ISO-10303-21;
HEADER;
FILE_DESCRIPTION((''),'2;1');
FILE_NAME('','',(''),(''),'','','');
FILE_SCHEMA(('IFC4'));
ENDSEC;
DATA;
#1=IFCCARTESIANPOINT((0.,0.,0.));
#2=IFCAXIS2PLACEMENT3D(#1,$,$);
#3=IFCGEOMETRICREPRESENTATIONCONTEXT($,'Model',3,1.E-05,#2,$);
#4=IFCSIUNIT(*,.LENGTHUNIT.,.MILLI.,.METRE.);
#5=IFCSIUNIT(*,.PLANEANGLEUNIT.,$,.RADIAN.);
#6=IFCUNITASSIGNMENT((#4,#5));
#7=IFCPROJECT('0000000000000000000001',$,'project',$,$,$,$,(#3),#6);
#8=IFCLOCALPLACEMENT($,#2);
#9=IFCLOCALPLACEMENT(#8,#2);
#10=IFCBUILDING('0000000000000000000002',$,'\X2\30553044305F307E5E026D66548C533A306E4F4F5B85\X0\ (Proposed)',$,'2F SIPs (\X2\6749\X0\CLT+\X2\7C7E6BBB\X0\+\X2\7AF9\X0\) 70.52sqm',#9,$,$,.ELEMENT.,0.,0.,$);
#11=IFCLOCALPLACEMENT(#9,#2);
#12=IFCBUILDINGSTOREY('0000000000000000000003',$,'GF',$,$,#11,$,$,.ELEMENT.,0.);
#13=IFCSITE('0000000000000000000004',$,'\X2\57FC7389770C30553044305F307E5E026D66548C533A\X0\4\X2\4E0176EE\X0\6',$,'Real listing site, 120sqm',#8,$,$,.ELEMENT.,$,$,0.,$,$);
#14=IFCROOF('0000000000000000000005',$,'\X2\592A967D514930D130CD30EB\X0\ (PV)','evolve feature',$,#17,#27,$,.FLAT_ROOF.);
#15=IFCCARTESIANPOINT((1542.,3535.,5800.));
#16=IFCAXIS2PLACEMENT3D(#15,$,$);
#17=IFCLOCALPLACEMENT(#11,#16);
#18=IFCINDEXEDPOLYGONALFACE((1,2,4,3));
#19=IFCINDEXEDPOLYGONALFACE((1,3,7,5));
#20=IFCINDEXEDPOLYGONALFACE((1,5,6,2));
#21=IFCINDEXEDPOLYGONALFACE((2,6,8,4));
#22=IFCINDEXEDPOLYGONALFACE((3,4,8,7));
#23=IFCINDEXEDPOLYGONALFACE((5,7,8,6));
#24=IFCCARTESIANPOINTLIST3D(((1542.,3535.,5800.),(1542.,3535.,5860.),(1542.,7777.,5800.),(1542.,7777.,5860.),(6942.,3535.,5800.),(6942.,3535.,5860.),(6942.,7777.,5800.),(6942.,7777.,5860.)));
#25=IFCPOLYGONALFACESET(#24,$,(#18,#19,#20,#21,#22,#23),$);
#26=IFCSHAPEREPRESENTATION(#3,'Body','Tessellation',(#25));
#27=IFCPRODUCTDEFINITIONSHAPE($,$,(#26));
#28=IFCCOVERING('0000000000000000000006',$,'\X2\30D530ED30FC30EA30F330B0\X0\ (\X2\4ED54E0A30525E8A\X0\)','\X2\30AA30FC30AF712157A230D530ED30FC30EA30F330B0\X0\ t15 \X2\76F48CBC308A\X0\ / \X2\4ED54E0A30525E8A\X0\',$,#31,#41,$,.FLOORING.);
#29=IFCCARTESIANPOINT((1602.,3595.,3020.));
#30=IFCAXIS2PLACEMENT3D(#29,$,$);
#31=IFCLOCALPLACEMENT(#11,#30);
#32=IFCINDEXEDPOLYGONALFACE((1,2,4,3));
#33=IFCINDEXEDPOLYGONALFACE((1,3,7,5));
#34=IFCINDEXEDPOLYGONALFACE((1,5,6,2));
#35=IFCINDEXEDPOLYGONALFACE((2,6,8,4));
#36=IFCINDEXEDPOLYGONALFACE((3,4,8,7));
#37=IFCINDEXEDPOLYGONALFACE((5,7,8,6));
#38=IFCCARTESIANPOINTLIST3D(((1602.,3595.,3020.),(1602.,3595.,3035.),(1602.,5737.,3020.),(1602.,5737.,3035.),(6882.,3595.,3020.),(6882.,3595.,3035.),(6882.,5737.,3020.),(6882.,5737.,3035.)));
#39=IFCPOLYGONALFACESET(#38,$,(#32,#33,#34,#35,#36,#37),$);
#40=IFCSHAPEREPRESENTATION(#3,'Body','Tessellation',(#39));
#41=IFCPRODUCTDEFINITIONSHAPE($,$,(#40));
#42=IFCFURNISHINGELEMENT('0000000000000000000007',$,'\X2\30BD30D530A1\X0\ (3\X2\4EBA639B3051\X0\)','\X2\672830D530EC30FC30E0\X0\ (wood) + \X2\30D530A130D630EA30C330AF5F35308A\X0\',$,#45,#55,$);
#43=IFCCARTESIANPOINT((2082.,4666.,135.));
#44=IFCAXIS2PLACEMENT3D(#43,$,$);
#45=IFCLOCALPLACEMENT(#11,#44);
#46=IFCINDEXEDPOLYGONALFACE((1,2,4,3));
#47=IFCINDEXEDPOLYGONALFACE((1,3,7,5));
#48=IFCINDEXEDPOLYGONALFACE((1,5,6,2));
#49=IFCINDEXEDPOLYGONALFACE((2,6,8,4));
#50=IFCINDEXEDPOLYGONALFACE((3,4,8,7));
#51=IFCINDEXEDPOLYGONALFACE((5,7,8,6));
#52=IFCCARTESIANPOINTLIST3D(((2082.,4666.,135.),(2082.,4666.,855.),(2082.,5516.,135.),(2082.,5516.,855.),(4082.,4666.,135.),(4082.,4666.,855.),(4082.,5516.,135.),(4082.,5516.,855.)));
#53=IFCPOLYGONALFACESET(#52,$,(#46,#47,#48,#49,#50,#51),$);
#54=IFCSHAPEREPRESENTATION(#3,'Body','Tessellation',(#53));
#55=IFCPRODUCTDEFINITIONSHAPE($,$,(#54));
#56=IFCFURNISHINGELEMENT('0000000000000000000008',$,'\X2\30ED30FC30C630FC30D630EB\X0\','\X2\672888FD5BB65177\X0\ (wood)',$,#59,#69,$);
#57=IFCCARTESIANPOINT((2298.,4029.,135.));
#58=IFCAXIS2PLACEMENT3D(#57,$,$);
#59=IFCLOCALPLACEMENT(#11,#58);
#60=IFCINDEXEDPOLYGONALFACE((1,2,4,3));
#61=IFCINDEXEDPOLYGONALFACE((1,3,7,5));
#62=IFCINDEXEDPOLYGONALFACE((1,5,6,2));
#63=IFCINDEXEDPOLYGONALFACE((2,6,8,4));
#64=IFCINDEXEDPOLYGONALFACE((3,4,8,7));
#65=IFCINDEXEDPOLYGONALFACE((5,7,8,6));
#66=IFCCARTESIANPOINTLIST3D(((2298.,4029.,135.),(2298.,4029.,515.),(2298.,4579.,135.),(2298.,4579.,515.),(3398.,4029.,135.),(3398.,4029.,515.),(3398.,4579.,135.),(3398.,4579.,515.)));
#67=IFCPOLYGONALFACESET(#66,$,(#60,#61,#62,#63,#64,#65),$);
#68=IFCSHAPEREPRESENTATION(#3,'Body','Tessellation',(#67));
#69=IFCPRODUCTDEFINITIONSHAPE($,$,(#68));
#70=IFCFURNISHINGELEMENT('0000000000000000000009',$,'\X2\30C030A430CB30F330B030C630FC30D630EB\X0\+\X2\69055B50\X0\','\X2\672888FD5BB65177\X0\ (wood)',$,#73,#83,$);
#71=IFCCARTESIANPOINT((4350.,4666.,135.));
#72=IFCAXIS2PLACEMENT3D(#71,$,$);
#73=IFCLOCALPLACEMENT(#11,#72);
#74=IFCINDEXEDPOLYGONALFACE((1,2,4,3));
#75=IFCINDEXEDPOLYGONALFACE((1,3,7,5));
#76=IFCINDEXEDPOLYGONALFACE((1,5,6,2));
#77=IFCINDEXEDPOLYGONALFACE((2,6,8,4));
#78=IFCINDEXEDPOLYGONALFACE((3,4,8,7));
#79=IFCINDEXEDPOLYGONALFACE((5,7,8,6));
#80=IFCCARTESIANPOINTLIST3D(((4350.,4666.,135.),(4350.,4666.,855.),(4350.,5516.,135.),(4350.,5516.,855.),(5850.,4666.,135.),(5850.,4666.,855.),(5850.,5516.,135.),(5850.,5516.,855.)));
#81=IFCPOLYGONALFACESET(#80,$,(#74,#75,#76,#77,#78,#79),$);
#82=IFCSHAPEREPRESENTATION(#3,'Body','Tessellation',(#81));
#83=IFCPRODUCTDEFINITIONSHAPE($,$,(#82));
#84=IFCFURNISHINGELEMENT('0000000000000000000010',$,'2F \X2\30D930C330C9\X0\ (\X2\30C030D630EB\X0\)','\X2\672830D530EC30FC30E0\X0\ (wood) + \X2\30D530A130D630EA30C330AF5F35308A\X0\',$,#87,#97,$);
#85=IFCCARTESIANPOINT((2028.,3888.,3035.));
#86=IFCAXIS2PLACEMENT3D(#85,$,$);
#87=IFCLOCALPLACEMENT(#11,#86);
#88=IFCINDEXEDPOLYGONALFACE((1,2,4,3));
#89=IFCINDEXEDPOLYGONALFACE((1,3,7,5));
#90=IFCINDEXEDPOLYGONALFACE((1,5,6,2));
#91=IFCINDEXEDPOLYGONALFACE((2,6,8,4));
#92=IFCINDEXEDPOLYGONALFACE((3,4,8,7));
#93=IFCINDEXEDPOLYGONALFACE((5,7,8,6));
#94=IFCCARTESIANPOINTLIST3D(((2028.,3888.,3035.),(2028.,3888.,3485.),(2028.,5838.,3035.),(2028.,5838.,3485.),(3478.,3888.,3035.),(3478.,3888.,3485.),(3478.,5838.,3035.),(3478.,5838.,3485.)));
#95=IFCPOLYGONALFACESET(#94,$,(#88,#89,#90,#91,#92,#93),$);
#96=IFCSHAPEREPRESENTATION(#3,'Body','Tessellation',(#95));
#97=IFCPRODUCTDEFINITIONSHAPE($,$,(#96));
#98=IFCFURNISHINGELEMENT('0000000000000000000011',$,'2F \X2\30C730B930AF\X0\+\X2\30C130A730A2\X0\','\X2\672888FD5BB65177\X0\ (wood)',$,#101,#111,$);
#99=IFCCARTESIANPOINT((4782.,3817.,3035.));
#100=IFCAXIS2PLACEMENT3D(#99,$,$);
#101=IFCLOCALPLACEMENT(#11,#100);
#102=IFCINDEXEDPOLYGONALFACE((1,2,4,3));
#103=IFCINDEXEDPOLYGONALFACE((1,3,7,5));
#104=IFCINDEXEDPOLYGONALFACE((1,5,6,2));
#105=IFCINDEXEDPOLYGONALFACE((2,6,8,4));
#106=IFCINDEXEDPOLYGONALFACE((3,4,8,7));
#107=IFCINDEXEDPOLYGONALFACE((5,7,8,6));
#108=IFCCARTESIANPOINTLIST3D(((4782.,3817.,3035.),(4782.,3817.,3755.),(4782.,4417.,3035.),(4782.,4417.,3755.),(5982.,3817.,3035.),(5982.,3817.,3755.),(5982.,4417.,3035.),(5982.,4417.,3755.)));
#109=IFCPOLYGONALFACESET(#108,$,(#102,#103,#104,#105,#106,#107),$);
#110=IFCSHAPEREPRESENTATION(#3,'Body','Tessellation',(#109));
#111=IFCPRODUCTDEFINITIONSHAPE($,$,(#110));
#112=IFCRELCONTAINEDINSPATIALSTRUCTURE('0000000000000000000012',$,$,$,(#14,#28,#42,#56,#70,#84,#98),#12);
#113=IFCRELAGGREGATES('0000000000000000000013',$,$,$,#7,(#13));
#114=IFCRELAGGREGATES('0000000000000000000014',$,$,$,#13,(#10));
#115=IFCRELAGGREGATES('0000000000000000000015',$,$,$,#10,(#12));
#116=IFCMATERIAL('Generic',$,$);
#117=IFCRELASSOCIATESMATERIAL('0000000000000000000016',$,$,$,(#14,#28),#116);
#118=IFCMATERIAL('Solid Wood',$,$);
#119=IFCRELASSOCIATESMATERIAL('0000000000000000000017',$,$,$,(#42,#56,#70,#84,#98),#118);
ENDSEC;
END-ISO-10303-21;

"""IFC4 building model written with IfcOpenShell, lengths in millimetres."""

from ifc_helpers import new_model, si_unit, frame, frame_2d, origin, place, context, project, spatial, rectangle, extrude, material, element, save


model = new_model("IFC4")

# Units and contexts
model_context = context("Model", 3, precision=1e-05, world=origin())
ifc_project = project(units=[si_unit("LENGTHUNIT", "METRE", prefix="MILLI"), si_unit("PLANEANGLEUNIT", "RADIAN")], contexts=[model_context])

# Site, building, storey
site_placement = place(None, origin())
site = spatial("IfcSite", under=ifc_project, at=site_placement, Name="埼玉県さいたま市浦和区4丁目6", ObjectType="Real listing site, 120sqm", CompositionType="ELEMENT", RefElevation=0.0)
building_placement = place(site_placement, origin())
building = spatial("IfcBuilding", under=site, at=building_placement, Name="さいたま市浦和区の住宅 (Proposed)", ObjectType="2F SIPs (杉CLT+籾殻+竹) 70.52sqm", CompositionType="ELEMENT", ElevationOfRefHeight=0.0, ElevationOfTerrain=0.0)
storey_placement = place(building_placement, origin())
storey = spatial("IfcBuildingStorey", under=building, at=storey_placement, Name="GF", CompositionType="ELEMENT", Elevation=0.0)

# Shared definitions
ifc_material_1 = material(Name="Solid Wood")

# Shared definitions
ifc_material_2 = material(Name="Generic")

# Roof
roof_1_placement = place(storey_placement, frame((1542.0, 3535.0, 5800.0)))
element("IfcRoof", 1, at=roof_1_placement, inside=storey, material=ifc_material_2, Name="太陽光パネル (PV)", Description="evolve feature", PredefinedType="FLAT_ROOF", context=model_context, shape_type="SweptSolid", body=[
    extrude(rectangle(XDim=5400.0, YDim=4242.0, at=frame_2d((2700.0, 2121.0))), frame((1542.0, 3535.0, 5800.0)), (0.0, 0.0, 1.0), 60.0),
])

# Covering
covering_placement = place(storey_placement, frame((1602.0, 3595.0, 3020.0)))
element("IfcCovering", 2, at=covering_placement, inside=storey, material=ifc_material_2, Name="フローリング (仕上げ床)", Description="オーク無垢フローリング t15 直貼り / 仕上げ床", PredefinedType="FLOORING", context=model_context, shape_type="SweptSolid", body=[
    extrude(rectangle(XDim=5280.0, YDim=2142.0, at=frame_2d((2640.0, 1071.0))), frame((1602.0, 3595.0, 3020.0)), (0.0, 0.0, 1.0), 15.0),
])

# Furnishing elements
furnishing_1_placement = place(storey_placement, frame((2082.0, 4666.0, 135.0)))
element("IfcFurnishingElement", 3, at=furnishing_1_placement, inside=storey, material=ifc_material_1, Name="ソファ (3人掛け)", Description="木フレーム (wood) + ファブリック張り", context=model_context, shape_type="SweptSolid", body=[
    extrude(rectangle(XDim=2000.0, YDim=850.0, at=frame_2d((1000.0, 425.0))), frame((2082.0, 4666.0, 135.0)), (0.0, 0.0, 1.0), 720.0),
])
furnishing_2_placement = place(storey_placement, frame((2298.0, 4029.0, 135.0)))
element("IfcFurnishingElement", 4, at=furnishing_2_placement, inside=storey, material=ifc_material_1, Name="ローテーブル", Description="木製家具 (wood)", context=model_context, shape_type="SweptSolid", body=[
    extrude(rectangle(XDim=1100.0, YDim=550.0, at=frame_2d((550.0, 275.0))), frame((2298.0, 4029.0, 135.0)), (0.0, 0.0, 1.0), 380.0),
])
furnishing_3_placement = place(storey_placement, frame((4350.0, 4666.0, 135.0)))
element("IfcFurnishingElement", 5, at=furnishing_3_placement, inside=storey, material=ifc_material_1, Name="ダイニングテーブル+椅子", Description="木製家具 (wood)", context=model_context, shape_type="SweptSolid", body=[
    extrude(rectangle(XDim=1500.0, YDim=850.0, at=frame_2d((750.0, 425.0))), frame((4350.0, 4666.0, 135.0)), (0.0, 0.0, 1.0), 720.0),
])
furnishing_4_placement = place(storey_placement, frame((2028.0, 3888.0, 3035.0)))
element("IfcFurnishingElement", 6, at=furnishing_4_placement, inside=storey, material=ifc_material_1, Name="2F ベッド (ダブル)", Description="木フレーム (wood) + ファブリック張り", context=model_context, shape_type="SweptSolid", body=[
    extrude(rectangle(XDim=1450.0, YDim=1950.0, at=frame_2d((725.0, 975.0))), frame((2028.0, 3888.0, 3035.0)), (0.0, 0.0, 1.0), 450.0),
])
furnishing_5_placement = place(storey_placement, frame((4782.0, 3817.0, 3035.0)))
element("IfcFurnishingElement", 7, at=furnishing_5_placement, inside=storey, material=ifc_material_1, Name="2F デスク+チェア", Description="木製家具 (wood)", context=model_context, shape_type="SweptSolid", body=[
    extrude(rectangle(XDim=1200.0, YDim=600.0, at=frame_2d((600.0, 300.0))), frame((4782.0, 3817.0, 3035.0)), (0.0, 0.0, 1.0), 720.0),
])

save(model, "model.ifc")
